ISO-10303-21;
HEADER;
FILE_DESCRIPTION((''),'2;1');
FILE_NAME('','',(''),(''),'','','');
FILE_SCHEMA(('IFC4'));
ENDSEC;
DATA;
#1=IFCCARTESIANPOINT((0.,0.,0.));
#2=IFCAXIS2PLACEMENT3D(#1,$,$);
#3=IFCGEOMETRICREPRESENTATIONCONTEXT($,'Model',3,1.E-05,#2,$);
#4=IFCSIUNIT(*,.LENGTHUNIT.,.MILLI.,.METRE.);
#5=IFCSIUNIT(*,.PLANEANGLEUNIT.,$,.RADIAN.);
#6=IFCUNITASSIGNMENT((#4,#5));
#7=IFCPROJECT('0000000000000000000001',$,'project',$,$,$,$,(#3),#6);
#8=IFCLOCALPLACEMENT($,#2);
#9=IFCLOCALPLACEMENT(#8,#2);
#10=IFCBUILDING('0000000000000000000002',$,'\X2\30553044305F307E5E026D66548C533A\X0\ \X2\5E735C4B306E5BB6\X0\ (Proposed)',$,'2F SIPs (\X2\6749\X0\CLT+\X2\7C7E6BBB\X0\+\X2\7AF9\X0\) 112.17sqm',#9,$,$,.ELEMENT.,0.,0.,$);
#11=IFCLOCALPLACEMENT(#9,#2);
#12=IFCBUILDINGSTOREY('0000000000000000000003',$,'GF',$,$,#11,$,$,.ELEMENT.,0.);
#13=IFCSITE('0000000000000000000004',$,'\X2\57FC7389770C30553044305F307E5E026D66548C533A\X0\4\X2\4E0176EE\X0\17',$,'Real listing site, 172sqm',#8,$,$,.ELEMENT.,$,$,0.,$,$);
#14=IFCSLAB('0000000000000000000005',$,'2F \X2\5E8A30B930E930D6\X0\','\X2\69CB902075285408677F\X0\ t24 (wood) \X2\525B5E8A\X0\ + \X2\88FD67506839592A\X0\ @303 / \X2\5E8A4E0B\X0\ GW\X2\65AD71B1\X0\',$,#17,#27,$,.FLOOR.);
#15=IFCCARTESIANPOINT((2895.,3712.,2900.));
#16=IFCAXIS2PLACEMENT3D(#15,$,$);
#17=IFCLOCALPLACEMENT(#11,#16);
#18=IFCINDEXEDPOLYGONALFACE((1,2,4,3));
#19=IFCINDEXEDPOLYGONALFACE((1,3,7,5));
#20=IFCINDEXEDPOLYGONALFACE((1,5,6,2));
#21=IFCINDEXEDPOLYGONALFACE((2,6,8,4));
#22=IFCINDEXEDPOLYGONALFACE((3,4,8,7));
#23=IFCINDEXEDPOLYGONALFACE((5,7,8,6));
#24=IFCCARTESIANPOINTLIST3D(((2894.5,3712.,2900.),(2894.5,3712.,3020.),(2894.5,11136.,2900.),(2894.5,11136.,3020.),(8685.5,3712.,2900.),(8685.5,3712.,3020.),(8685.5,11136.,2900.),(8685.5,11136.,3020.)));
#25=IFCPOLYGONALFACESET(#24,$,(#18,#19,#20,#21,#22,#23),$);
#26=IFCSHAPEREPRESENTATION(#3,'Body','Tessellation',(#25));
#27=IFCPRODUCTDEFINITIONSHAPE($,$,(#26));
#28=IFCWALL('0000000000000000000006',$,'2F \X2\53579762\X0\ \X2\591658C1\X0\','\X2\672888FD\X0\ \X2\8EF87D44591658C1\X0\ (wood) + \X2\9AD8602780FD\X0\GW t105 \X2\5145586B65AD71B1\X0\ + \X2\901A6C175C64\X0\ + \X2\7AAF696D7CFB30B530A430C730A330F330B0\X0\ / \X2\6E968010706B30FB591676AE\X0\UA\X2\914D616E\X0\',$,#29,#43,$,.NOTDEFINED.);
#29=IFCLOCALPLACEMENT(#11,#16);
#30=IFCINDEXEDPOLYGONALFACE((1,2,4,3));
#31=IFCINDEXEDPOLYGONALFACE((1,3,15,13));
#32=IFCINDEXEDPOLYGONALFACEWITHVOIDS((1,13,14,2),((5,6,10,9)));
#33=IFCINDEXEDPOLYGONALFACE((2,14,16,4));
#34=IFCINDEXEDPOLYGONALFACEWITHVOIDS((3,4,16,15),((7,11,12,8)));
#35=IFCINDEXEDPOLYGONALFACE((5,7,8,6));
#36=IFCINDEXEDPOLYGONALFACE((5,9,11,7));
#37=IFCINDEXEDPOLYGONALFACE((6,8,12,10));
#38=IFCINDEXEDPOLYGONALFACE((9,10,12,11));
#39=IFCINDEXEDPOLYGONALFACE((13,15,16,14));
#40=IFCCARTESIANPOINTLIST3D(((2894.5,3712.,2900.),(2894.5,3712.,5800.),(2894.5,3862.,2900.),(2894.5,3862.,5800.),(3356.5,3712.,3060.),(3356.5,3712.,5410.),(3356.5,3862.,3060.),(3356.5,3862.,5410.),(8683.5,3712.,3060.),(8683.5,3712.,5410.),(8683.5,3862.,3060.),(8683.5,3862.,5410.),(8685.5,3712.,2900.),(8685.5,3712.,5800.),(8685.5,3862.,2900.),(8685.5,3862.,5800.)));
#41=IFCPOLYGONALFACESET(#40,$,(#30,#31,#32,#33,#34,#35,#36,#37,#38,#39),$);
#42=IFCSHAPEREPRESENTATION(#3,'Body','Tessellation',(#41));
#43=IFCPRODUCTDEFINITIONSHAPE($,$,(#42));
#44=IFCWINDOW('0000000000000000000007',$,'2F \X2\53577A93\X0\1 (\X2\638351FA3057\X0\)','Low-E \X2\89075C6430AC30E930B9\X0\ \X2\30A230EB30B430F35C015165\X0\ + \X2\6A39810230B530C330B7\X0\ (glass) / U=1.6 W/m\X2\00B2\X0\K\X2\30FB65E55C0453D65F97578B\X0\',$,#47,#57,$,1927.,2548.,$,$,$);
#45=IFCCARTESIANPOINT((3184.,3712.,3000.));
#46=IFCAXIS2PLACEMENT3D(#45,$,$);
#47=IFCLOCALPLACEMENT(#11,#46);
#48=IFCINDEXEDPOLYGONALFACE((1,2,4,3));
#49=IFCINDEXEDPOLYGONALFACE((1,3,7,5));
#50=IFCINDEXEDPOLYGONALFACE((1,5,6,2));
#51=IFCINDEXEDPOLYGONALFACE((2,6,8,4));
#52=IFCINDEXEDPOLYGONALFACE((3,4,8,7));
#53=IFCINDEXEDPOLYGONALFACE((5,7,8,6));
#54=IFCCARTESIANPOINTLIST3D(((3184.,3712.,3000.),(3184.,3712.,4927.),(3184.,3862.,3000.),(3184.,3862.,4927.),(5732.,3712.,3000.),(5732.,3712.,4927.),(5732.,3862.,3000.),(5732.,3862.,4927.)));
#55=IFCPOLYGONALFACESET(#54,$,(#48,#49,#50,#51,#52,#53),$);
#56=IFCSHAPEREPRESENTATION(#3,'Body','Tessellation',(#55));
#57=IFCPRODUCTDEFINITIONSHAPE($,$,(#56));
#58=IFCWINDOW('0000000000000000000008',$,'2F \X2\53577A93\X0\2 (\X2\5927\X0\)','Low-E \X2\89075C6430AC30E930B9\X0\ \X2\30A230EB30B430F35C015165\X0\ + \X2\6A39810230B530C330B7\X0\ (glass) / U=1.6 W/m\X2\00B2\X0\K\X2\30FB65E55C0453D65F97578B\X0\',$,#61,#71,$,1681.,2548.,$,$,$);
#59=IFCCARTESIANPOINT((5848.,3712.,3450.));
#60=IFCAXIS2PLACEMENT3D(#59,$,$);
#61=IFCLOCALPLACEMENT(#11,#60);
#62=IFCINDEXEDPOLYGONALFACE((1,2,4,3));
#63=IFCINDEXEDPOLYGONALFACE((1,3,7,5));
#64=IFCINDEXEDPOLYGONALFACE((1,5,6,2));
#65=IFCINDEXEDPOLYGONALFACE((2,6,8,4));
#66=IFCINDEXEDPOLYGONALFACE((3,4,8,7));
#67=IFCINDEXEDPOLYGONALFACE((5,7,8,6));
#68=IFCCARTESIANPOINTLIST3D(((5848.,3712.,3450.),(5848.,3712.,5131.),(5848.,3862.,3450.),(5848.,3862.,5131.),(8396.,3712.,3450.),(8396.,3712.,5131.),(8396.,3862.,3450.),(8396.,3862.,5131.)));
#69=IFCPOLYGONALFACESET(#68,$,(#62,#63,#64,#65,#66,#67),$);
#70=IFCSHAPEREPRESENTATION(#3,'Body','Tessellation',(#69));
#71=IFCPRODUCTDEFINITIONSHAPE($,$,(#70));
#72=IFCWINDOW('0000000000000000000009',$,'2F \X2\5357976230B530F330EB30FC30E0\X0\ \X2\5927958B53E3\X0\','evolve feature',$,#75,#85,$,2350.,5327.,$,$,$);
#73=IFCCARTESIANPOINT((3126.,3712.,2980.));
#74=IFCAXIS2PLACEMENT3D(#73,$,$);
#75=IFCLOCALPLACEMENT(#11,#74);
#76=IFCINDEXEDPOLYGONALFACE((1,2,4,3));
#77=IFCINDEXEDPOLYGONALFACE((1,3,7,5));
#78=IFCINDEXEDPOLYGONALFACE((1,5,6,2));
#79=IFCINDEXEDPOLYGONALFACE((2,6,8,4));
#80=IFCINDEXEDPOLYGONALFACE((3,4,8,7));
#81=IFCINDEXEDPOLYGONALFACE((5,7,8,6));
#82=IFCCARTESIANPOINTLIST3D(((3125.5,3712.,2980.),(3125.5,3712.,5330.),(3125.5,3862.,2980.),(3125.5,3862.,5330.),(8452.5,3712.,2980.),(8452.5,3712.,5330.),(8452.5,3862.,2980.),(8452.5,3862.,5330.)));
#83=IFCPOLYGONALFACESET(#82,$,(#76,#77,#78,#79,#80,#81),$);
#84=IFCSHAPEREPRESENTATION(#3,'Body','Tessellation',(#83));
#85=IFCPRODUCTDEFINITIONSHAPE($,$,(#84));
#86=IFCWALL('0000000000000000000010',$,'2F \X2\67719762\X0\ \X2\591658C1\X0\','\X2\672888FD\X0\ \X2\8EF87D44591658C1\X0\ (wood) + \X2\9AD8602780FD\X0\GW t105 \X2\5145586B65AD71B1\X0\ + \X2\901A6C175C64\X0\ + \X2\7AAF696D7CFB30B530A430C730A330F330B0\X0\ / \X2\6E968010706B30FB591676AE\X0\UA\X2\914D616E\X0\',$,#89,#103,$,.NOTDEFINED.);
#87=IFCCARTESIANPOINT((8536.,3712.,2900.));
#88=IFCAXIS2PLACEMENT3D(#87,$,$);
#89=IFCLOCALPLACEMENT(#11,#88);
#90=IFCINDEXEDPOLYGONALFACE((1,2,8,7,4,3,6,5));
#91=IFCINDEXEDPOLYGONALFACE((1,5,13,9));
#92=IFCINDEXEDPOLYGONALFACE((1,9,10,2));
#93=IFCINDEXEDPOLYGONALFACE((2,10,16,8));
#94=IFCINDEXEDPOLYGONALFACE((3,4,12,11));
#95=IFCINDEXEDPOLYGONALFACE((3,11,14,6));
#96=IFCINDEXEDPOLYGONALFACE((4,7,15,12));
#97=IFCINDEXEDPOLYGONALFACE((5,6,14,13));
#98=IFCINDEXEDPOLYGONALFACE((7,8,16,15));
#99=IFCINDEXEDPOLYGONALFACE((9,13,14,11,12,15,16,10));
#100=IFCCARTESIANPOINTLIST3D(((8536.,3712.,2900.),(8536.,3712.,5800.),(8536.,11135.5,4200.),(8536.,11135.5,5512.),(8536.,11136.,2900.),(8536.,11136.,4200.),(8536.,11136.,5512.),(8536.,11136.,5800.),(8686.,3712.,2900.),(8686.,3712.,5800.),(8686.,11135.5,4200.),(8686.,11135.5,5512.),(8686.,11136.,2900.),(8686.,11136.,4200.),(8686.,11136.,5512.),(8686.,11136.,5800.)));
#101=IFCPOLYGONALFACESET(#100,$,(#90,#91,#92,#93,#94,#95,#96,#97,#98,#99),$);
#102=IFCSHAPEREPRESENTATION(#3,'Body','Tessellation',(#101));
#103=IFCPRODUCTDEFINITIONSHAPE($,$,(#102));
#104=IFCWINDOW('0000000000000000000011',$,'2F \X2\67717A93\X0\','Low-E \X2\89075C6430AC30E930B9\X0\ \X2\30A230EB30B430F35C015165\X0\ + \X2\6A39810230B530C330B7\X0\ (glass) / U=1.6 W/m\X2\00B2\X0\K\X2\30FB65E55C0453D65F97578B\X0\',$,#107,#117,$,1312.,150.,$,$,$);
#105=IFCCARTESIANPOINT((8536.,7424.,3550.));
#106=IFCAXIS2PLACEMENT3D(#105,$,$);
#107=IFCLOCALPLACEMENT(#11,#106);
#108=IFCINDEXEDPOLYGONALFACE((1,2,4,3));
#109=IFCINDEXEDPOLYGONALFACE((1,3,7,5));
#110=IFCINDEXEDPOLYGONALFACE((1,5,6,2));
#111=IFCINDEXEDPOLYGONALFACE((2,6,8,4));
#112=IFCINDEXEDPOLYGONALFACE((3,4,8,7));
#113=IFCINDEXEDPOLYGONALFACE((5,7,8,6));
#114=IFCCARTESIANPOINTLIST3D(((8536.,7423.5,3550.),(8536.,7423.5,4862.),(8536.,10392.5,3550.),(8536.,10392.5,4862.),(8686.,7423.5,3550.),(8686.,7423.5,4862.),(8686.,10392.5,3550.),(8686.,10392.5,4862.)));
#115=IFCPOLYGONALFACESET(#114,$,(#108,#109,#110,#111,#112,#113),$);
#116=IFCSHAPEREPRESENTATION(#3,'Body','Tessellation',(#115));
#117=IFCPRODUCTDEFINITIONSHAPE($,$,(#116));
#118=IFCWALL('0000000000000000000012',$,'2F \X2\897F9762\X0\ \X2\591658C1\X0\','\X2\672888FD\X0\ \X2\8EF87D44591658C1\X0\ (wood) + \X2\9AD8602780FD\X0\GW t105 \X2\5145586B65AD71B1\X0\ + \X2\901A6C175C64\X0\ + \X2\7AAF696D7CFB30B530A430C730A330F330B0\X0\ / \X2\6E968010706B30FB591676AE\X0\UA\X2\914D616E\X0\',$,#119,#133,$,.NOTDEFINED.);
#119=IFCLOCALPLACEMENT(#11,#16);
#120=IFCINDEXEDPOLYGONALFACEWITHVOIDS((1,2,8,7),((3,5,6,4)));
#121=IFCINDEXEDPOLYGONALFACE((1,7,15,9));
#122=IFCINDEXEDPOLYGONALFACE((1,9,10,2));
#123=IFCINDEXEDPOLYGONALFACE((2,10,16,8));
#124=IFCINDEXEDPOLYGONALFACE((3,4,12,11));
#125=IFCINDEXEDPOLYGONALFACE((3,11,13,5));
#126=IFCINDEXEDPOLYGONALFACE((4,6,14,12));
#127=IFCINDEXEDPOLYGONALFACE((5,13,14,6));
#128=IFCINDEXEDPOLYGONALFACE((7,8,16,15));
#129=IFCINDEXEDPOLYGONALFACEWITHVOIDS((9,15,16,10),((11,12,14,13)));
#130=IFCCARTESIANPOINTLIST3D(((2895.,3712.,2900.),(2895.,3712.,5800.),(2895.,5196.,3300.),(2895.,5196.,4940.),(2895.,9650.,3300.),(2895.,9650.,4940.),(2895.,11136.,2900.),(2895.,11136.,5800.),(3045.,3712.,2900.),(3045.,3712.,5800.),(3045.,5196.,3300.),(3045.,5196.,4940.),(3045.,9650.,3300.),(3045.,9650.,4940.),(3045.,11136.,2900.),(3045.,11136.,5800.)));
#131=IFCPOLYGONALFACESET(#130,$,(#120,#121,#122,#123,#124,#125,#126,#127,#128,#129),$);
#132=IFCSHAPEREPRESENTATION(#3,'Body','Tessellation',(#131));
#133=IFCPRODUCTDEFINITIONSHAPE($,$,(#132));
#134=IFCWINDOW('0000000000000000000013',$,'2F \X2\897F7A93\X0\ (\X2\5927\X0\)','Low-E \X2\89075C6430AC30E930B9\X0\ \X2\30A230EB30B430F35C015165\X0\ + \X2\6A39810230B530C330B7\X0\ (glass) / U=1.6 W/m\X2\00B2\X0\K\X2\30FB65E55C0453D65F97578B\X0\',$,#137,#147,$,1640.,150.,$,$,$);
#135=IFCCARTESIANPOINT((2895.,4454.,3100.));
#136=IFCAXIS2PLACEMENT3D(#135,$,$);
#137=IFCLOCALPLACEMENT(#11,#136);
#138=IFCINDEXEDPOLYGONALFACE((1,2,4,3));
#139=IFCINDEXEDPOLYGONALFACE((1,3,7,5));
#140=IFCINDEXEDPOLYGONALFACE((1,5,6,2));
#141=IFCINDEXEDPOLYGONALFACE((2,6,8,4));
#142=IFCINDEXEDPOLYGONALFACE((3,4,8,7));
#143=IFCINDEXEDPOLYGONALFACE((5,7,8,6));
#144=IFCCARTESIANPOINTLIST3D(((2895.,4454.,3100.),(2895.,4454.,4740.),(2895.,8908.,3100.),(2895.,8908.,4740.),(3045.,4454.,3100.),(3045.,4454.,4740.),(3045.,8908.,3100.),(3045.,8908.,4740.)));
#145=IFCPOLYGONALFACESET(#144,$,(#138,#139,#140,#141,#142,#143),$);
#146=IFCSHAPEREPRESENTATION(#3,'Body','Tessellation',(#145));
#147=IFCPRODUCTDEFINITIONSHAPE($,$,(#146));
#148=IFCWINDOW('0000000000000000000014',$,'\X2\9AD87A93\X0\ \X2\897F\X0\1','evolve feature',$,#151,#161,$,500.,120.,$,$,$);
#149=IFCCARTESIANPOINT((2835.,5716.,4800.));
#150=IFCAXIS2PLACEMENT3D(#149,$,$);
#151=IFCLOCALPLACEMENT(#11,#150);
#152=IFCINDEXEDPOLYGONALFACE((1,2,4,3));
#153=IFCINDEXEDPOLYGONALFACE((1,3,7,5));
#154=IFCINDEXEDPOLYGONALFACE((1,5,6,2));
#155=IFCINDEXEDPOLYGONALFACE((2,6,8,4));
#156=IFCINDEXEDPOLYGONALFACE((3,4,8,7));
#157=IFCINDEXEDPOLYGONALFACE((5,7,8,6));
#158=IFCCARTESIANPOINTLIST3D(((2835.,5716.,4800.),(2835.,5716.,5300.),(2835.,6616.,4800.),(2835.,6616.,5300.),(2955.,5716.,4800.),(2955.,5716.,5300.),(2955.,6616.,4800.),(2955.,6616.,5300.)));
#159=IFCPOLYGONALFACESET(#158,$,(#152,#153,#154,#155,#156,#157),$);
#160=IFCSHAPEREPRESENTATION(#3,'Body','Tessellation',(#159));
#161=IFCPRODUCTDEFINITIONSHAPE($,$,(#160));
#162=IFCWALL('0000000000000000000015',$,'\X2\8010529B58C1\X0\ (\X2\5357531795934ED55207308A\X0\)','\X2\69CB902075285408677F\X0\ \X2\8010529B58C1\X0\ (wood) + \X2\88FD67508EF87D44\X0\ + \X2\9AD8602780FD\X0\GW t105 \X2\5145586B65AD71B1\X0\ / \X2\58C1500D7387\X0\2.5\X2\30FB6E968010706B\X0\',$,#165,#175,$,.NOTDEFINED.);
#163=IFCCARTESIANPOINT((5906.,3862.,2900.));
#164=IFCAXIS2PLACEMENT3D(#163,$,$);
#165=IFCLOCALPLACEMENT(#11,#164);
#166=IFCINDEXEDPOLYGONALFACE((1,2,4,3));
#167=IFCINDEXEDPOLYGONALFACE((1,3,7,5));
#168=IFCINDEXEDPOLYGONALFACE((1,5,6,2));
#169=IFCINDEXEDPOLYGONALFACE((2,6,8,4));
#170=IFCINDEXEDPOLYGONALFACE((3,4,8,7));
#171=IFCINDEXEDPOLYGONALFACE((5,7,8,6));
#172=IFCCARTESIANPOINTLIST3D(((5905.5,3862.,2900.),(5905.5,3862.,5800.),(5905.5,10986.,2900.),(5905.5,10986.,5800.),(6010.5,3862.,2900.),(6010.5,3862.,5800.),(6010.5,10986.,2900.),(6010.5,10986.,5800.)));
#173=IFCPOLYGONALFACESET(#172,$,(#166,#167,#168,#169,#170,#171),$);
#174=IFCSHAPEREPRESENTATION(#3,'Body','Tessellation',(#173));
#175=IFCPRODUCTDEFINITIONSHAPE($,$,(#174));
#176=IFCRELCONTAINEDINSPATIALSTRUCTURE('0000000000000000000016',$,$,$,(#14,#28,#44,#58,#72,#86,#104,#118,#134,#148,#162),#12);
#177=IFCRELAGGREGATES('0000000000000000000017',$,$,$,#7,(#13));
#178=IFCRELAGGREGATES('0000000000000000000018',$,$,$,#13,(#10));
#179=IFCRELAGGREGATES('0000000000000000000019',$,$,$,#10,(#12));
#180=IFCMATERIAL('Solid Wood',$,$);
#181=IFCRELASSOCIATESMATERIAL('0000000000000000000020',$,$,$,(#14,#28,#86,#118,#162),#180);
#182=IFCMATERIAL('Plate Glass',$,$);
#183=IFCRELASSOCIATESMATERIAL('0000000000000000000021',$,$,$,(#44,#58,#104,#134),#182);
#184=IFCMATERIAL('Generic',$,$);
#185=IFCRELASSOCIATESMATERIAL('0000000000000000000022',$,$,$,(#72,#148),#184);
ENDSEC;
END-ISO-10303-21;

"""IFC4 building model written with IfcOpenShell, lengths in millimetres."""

from ifc_helpers import new_model, si_unit, frame, frame_2d, origin, place, context, project, spatial, rectangle, extrude, material, element, fill, save


model = new_model("IFC4")

# Units and contexts
model_context = context("Model", 3, precision=1e-05, world=origin())
ifc_project = project(units=[si_unit("LENGTHUNIT", "METRE", prefix="MILLI"), si_unit("PLANEANGLEUNIT", "RADIAN")], contexts=[model_context])

# Site, building, storey
site_placement = place(None, origin())
site = spatial("IfcSite", under=ifc_project, at=site_placement, Name="埼玉県さいたま市浦和区4丁目17", ObjectType="Real listing site, 172sqm", CompositionType="ELEMENT", RefElevation=0.0)
building_placement = place(site_placement, origin())
building = spatial("IfcBuilding", under=site, at=building_placement, Name="さいたま市浦和区 平屋の家 (Proposed)", ObjectType="2F SIPs (杉CLT+籾殻+竹) 112.17sqm", CompositionType="ELEMENT", ElevationOfRefHeight=0.0, ElevationOfTerrain=0.0)
storey_placement = place(building_placement, origin())
storey = spatial("IfcBuildingStorey", under=building, at=storey_placement, Name="GF", CompositionType="ELEMENT", Elevation=0.0)

# Slab
ifc_material_1 = material(Name="Solid Wood")
slab_placement = place(storey_placement, frame((2895.0, 3712.0, 2900.0)))
element("IfcSlab", 1, at=slab_placement, inside=storey, material=ifc_material_1, Name="2F 床スラブ", Description="構造用合板 t24 (wood) 剛床 + 製材根太 @303 / 床下 GW断熱", PredefinedType="FLOOR", context=model_context, shape_type="SweptSolid", body=[
    extrude(rectangle(XDim=5791.0, YDim=7424.0, at=frame_2d((2895.0, 3712.0))), frame((2895.0, 3712.0, 2900.0)), (0.0, 0.0, 1.0), 120.0),
])

# Wall, openings, windows
wall_1_placement = place(storey_placement, frame((2895.0, 3712.0, 2900.0)))
wall_1 = element("IfcWall", 2, at=wall_1_placement, inside=storey, material=ifc_material_1, Name="2F 南面 外壁", Description="木製 軸組外壁 (wood) + 高性能GW t105 充填断熱 + 通気層 + 窯業系サイディング / 準耐火・外皮UA配慮", PredefinedType="NOTDEFINED", context=model_context, shape_type="SweptSolid", body=[
    extrude(rectangle(XDim=5791.0, YDim=150.0, at=frame_2d((2895.0, 75.0))), frame((2895.0, 3712.0, 2900.0)), (0.0, 0.0, 1.0), 2900.0),
])
opening_1_placement = place(storey_placement, frame((3184.0, 3712.0, 3000.0)))
opening_1 = element("IfcOpeningElement", 3, at=opening_1_placement, cuts=wall_1, PredefinedType="NOTDEFINED", context=model_context, shape_type="SweptSolid", body=[
    extrude(rectangle(XDim=2548.0, YDim=150.0, at=frame_2d((1274.0, 75.0))), frame((3184.0, 3712.0, 3000.0)), (0.0, 0.0, 1.0), 1927.0),
])
opening_2_placement = place(storey_placement, frame((5848.0, 3712.0, 3450.0)))
opening_2 = element("IfcOpeningElement", 4, at=opening_2_placement, cuts=wall_1, PredefinedType="NOTDEFINED", context=model_context, shape_type="SweptSolid", body=[
    extrude(rectangle(XDim=2548.0, YDim=150.0, at=frame_2d((1274.0, 75.0))), frame((5848.0, 3712.0, 3450.0)), (0.0, 0.0, 1.0), 1681.0),
])
opening_3_placement = place(storey_placement, frame((3126.0, 3712.0, 2980.0)))
opening_3 = element("IfcOpeningElement", 5, at=opening_3_placement, cuts=wall_1, PredefinedType="NOTDEFINED", context=model_context, shape_type="SweptSolid", body=[
    extrude(rectangle(XDim=5327.0, YDim=150.0, at=frame_2d((2663.0, 75.0))), frame((3126.0, 3712.0, 2980.0)), (0.0, 0.0, 1.0), 2350.0),
])
ifc_material_2 = material(Name="Plate Glass")
window_1_placement = place(storey_placement, frame((3184.0, 3712.0, 3000.0)))
window_1 = element("IfcWindow", 6, at=window_1_placement, inside=storey, material=ifc_material_2, Name="2F 南窓1 (掃出し)", Description="Low-E 複層ガラス アルゴン封入 + 樹脂サッシ (glass) / U=1.6 W/m²K・日射取得型", OverallHeight=1927.0, OverallWidth=2548.0, context=model_context, shape_type="SweptSolid", body=[
    extrude(rectangle(XDim=2548.0, YDim=150.0, at=frame_2d((1274.0, 75.0))), frame((3184.0, 3712.0, 3000.0)), (0.0, 0.0, 1.0), 1927.0),
])
fill(opening_1, window_1)
window_2_placement = place(storey_placement, frame((5848.0, 3712.0, 3450.0)))
window_2 = element("IfcWindow", 7, at=window_2_placement, inside=storey, material=ifc_material_2, Name="2F 南窓2 (大)", Description="Low-E 複層ガラス アルゴン封入 + 樹脂サッシ (glass) / U=1.6 W/m²K・日射取得型", OverallHeight=1681.0, OverallWidth=2548.0, context=model_context, shape_type="SweptSolid", body=[
    extrude(rectangle(XDim=2548.0, YDim=150.0, at=frame_2d((1274.0, 75.0))), frame((5848.0, 3712.0, 3450.0)), (0.0, 0.0, 1.0), 1681.0),
])
fill(opening_2, window_2)
ifc_material_3 = material(Name="Generic")
window_3_placement = place(storey_placement, frame((3126.0, 3712.0, 2980.0)))
window_3 = element("IfcWindow", 8, at=window_3_placement, inside=storey, material=ifc_material_3, Name="2F 南面サンルーム 大開口", Description="evolve feature", OverallHeight=2350.0, OverallWidth=5327.0, context=model_context, shape_type="SweptSolid", body=[
    extrude(rectangle(XDim=5327.0, YDim=150.0, at=frame_2d((2663.0, 75.0))), frame((3126.0, 3712.0, 2980.0)), (0.0, 0.0, 1.0), 2350.0),
])
fill(opening_3, window_3)

# Wall, opening, window
wall_2_placement = place(storey_placement, frame((8536.0, 3712.0, 2900.0)))
wall_2 = element("IfcWall", 9, at=wall_2_placement, inside=storey, material=ifc_material_1, Name="2F 東面 外壁", Description="木製 軸組外壁 (wood) + 高性能GW t105 充填断熱 + 通気層 + 窯業系サイディング / 準耐火・外皮UA配慮", PredefinedType="NOTDEFINED", context=model_context, shape_type="SweptSolid", body=[
    extrude(rectangle(XDim=150.0, YDim=7424.0, at=frame_2d((75.0, 3712.0))), frame((8536.0, 3712.0, 2900.0)), (0.0, 0.0, 1.0), 2900.0),
])
opening_4_placement = place(storey_placement, frame((8536.0, 7424.0, 3550.0)))
opening_4 = element("IfcOpeningElement", 10, at=opening_4_placement, cuts=wall_2, PredefinedType="NOTDEFINED", context=model_context, shape_type="SweptSolid", body=[
    extrude(rectangle(XDim=150.0, YDim=2969.0, at=frame_2d((75.0, 1484.0))), frame((8536.0, 7424.0, 3550.0)), (0.0, 0.0, 1.0), 1312.0),
])
window_4_placement = place(storey_placement, frame((8536.0, 7424.0, 3550.0)))
window_4 = element("IfcWindow", 11, at=window_4_placement, inside=storey, material=ifc_material_2, Name="2F 東窓", Description="Low-E 複層ガラス アルゴン封入 + 樹脂サッシ (glass) / U=1.6 W/m²K・日射取得型", OverallHeight=1312.0, OverallWidth=150.0, context=model_context, shape_type="SweptSolid", body=[
    extrude(rectangle(XDim=150.0, YDim=2969.0, at=frame_2d((75.0, 1484.0))), frame((8536.0, 7424.0, 3550.0)), (0.0, 0.0, 1.0), 1312.0),
])
fill(opening_4, window_4)

# Wall, openings, windows
wall_3_placement = place(storey_placement, frame((2895.0, 3712.0, 2900.0)))
wall_3 = element("IfcWall", 12, at=wall_3_placement, inside=storey, material=ifc_material_1, Name="2F 西面 外壁", Description="木製 軸組外壁 (wood) + 高性能GW t105 充填断熱 + 通気層 + 窯業系サイディング / 準耐火・外皮UA配慮", PredefinedType="NOTDEFINED", context=model_context, shape_type="SweptSolid", body=[
    extrude(rectangle(XDim=150.0, YDim=7424.0, at=frame_2d((75.0, 3712.0))), frame((2895.0, 3712.0, 2900.0)), (0.0, 0.0, 1.0), 2900.0),
])
opening_5_placement = place(storey_placement, frame((2895.0, 4454.0, 3100.0)))
opening_5 = element("IfcOpeningElement", 13, at=opening_5_placement, cuts=wall_3, PredefinedType="NOTDEFINED", context=model_context, shape_type="SweptSolid", body=[
    extrude(rectangle(XDim=150.0, YDim=4454.0, at=frame_2d((75.0, 2227.0))), frame((2895.0, 4454.0, 3100.0)), (0.0, 0.0, 1.0), 1640.0),
])
opening_6_placement = place(storey_placement, frame((2835.0, 5716.0, 4800.0)))
opening_6 = element("IfcOpeningElement", 14, at=opening_6_placement, cuts=wall_3, PredefinedType="NOTDEFINED", context=model_context, shape_type="SweptSolid", body=[
    extrude(rectangle(XDim=120.0, YDim=900.0, at=frame_2d((60.0, 450.0))), frame((2835.0, 5716.0, 4800.0)), (0.0, 0.0, 1.0), 500.0),
])
window_5_placement = place(storey_placement, frame((2895.0, 4454.0, 3100.0)))
window_5 = element("IfcWindow", 15, at=window_5_placement, inside=storey, material=ifc_material_2, Name="2F 西窓 (大)", Description="Low-E 複層ガラス アルゴン封入 + 樹脂サッシ (glass) / U=1.6 W/m²K・日射取得型", OverallHeight=1640.0, OverallWidth=150.0, context=model_context, shape_type="SweptSolid", body=[
    extrude(rectangle(XDim=150.0, YDim=4454.0, at=frame_2d((75.0, 2227.0))), frame((2895.0, 4454.0, 3100.0)), (0.0, 0.0, 1.0), 1640.0),
])
fill(opening_5, window_5)
window_6_placement = place(storey_placement, frame((2835.0, 5716.0, 4800.0)))
window_6 = element("IfcWindow", 16, at=window_6_placement, inside=storey, material=ifc_material_3, Name="高窓 西1", Description="evolve feature", OverallHeight=500.0, OverallWidth=120.0, context=model_context, shape_type="SweptSolid", body=[
    extrude(rectangle(XDim=120.0, YDim=900.0, at=frame_2d((60.0, 450.0))), frame((2835.0, 5716.0, 4800.0)), (0.0, 0.0, 1.0), 500.0),
])
fill(opening_6, window_6)

# Wall
wall_4_placement = place(storey_placement, frame((5906.0, 3862.0, 2900.0)))
element("IfcWall", 17, at=wall_4_placement, inside=storey, material=ifc_material_1, Name="耐力壁 (南北間仕切り)", Description="構造用合板 耐力壁 (wood) + 製材軸組 + 高性能GW t105 充填断熱 / 壁倍率2.5・準耐火", PredefinedType="NOTDEFINED", context=model_context, shape_type="SweptSolid", body=[
    extrude(rectangle(XDim=105.0, YDim=7124.0, at=frame_2d((52.0, 3562.0))), frame((5906.0, 3862.0, 2900.0)), (0.0, 0.0, 1.0), 2900.0),
])

save(model, "model.ifc")
